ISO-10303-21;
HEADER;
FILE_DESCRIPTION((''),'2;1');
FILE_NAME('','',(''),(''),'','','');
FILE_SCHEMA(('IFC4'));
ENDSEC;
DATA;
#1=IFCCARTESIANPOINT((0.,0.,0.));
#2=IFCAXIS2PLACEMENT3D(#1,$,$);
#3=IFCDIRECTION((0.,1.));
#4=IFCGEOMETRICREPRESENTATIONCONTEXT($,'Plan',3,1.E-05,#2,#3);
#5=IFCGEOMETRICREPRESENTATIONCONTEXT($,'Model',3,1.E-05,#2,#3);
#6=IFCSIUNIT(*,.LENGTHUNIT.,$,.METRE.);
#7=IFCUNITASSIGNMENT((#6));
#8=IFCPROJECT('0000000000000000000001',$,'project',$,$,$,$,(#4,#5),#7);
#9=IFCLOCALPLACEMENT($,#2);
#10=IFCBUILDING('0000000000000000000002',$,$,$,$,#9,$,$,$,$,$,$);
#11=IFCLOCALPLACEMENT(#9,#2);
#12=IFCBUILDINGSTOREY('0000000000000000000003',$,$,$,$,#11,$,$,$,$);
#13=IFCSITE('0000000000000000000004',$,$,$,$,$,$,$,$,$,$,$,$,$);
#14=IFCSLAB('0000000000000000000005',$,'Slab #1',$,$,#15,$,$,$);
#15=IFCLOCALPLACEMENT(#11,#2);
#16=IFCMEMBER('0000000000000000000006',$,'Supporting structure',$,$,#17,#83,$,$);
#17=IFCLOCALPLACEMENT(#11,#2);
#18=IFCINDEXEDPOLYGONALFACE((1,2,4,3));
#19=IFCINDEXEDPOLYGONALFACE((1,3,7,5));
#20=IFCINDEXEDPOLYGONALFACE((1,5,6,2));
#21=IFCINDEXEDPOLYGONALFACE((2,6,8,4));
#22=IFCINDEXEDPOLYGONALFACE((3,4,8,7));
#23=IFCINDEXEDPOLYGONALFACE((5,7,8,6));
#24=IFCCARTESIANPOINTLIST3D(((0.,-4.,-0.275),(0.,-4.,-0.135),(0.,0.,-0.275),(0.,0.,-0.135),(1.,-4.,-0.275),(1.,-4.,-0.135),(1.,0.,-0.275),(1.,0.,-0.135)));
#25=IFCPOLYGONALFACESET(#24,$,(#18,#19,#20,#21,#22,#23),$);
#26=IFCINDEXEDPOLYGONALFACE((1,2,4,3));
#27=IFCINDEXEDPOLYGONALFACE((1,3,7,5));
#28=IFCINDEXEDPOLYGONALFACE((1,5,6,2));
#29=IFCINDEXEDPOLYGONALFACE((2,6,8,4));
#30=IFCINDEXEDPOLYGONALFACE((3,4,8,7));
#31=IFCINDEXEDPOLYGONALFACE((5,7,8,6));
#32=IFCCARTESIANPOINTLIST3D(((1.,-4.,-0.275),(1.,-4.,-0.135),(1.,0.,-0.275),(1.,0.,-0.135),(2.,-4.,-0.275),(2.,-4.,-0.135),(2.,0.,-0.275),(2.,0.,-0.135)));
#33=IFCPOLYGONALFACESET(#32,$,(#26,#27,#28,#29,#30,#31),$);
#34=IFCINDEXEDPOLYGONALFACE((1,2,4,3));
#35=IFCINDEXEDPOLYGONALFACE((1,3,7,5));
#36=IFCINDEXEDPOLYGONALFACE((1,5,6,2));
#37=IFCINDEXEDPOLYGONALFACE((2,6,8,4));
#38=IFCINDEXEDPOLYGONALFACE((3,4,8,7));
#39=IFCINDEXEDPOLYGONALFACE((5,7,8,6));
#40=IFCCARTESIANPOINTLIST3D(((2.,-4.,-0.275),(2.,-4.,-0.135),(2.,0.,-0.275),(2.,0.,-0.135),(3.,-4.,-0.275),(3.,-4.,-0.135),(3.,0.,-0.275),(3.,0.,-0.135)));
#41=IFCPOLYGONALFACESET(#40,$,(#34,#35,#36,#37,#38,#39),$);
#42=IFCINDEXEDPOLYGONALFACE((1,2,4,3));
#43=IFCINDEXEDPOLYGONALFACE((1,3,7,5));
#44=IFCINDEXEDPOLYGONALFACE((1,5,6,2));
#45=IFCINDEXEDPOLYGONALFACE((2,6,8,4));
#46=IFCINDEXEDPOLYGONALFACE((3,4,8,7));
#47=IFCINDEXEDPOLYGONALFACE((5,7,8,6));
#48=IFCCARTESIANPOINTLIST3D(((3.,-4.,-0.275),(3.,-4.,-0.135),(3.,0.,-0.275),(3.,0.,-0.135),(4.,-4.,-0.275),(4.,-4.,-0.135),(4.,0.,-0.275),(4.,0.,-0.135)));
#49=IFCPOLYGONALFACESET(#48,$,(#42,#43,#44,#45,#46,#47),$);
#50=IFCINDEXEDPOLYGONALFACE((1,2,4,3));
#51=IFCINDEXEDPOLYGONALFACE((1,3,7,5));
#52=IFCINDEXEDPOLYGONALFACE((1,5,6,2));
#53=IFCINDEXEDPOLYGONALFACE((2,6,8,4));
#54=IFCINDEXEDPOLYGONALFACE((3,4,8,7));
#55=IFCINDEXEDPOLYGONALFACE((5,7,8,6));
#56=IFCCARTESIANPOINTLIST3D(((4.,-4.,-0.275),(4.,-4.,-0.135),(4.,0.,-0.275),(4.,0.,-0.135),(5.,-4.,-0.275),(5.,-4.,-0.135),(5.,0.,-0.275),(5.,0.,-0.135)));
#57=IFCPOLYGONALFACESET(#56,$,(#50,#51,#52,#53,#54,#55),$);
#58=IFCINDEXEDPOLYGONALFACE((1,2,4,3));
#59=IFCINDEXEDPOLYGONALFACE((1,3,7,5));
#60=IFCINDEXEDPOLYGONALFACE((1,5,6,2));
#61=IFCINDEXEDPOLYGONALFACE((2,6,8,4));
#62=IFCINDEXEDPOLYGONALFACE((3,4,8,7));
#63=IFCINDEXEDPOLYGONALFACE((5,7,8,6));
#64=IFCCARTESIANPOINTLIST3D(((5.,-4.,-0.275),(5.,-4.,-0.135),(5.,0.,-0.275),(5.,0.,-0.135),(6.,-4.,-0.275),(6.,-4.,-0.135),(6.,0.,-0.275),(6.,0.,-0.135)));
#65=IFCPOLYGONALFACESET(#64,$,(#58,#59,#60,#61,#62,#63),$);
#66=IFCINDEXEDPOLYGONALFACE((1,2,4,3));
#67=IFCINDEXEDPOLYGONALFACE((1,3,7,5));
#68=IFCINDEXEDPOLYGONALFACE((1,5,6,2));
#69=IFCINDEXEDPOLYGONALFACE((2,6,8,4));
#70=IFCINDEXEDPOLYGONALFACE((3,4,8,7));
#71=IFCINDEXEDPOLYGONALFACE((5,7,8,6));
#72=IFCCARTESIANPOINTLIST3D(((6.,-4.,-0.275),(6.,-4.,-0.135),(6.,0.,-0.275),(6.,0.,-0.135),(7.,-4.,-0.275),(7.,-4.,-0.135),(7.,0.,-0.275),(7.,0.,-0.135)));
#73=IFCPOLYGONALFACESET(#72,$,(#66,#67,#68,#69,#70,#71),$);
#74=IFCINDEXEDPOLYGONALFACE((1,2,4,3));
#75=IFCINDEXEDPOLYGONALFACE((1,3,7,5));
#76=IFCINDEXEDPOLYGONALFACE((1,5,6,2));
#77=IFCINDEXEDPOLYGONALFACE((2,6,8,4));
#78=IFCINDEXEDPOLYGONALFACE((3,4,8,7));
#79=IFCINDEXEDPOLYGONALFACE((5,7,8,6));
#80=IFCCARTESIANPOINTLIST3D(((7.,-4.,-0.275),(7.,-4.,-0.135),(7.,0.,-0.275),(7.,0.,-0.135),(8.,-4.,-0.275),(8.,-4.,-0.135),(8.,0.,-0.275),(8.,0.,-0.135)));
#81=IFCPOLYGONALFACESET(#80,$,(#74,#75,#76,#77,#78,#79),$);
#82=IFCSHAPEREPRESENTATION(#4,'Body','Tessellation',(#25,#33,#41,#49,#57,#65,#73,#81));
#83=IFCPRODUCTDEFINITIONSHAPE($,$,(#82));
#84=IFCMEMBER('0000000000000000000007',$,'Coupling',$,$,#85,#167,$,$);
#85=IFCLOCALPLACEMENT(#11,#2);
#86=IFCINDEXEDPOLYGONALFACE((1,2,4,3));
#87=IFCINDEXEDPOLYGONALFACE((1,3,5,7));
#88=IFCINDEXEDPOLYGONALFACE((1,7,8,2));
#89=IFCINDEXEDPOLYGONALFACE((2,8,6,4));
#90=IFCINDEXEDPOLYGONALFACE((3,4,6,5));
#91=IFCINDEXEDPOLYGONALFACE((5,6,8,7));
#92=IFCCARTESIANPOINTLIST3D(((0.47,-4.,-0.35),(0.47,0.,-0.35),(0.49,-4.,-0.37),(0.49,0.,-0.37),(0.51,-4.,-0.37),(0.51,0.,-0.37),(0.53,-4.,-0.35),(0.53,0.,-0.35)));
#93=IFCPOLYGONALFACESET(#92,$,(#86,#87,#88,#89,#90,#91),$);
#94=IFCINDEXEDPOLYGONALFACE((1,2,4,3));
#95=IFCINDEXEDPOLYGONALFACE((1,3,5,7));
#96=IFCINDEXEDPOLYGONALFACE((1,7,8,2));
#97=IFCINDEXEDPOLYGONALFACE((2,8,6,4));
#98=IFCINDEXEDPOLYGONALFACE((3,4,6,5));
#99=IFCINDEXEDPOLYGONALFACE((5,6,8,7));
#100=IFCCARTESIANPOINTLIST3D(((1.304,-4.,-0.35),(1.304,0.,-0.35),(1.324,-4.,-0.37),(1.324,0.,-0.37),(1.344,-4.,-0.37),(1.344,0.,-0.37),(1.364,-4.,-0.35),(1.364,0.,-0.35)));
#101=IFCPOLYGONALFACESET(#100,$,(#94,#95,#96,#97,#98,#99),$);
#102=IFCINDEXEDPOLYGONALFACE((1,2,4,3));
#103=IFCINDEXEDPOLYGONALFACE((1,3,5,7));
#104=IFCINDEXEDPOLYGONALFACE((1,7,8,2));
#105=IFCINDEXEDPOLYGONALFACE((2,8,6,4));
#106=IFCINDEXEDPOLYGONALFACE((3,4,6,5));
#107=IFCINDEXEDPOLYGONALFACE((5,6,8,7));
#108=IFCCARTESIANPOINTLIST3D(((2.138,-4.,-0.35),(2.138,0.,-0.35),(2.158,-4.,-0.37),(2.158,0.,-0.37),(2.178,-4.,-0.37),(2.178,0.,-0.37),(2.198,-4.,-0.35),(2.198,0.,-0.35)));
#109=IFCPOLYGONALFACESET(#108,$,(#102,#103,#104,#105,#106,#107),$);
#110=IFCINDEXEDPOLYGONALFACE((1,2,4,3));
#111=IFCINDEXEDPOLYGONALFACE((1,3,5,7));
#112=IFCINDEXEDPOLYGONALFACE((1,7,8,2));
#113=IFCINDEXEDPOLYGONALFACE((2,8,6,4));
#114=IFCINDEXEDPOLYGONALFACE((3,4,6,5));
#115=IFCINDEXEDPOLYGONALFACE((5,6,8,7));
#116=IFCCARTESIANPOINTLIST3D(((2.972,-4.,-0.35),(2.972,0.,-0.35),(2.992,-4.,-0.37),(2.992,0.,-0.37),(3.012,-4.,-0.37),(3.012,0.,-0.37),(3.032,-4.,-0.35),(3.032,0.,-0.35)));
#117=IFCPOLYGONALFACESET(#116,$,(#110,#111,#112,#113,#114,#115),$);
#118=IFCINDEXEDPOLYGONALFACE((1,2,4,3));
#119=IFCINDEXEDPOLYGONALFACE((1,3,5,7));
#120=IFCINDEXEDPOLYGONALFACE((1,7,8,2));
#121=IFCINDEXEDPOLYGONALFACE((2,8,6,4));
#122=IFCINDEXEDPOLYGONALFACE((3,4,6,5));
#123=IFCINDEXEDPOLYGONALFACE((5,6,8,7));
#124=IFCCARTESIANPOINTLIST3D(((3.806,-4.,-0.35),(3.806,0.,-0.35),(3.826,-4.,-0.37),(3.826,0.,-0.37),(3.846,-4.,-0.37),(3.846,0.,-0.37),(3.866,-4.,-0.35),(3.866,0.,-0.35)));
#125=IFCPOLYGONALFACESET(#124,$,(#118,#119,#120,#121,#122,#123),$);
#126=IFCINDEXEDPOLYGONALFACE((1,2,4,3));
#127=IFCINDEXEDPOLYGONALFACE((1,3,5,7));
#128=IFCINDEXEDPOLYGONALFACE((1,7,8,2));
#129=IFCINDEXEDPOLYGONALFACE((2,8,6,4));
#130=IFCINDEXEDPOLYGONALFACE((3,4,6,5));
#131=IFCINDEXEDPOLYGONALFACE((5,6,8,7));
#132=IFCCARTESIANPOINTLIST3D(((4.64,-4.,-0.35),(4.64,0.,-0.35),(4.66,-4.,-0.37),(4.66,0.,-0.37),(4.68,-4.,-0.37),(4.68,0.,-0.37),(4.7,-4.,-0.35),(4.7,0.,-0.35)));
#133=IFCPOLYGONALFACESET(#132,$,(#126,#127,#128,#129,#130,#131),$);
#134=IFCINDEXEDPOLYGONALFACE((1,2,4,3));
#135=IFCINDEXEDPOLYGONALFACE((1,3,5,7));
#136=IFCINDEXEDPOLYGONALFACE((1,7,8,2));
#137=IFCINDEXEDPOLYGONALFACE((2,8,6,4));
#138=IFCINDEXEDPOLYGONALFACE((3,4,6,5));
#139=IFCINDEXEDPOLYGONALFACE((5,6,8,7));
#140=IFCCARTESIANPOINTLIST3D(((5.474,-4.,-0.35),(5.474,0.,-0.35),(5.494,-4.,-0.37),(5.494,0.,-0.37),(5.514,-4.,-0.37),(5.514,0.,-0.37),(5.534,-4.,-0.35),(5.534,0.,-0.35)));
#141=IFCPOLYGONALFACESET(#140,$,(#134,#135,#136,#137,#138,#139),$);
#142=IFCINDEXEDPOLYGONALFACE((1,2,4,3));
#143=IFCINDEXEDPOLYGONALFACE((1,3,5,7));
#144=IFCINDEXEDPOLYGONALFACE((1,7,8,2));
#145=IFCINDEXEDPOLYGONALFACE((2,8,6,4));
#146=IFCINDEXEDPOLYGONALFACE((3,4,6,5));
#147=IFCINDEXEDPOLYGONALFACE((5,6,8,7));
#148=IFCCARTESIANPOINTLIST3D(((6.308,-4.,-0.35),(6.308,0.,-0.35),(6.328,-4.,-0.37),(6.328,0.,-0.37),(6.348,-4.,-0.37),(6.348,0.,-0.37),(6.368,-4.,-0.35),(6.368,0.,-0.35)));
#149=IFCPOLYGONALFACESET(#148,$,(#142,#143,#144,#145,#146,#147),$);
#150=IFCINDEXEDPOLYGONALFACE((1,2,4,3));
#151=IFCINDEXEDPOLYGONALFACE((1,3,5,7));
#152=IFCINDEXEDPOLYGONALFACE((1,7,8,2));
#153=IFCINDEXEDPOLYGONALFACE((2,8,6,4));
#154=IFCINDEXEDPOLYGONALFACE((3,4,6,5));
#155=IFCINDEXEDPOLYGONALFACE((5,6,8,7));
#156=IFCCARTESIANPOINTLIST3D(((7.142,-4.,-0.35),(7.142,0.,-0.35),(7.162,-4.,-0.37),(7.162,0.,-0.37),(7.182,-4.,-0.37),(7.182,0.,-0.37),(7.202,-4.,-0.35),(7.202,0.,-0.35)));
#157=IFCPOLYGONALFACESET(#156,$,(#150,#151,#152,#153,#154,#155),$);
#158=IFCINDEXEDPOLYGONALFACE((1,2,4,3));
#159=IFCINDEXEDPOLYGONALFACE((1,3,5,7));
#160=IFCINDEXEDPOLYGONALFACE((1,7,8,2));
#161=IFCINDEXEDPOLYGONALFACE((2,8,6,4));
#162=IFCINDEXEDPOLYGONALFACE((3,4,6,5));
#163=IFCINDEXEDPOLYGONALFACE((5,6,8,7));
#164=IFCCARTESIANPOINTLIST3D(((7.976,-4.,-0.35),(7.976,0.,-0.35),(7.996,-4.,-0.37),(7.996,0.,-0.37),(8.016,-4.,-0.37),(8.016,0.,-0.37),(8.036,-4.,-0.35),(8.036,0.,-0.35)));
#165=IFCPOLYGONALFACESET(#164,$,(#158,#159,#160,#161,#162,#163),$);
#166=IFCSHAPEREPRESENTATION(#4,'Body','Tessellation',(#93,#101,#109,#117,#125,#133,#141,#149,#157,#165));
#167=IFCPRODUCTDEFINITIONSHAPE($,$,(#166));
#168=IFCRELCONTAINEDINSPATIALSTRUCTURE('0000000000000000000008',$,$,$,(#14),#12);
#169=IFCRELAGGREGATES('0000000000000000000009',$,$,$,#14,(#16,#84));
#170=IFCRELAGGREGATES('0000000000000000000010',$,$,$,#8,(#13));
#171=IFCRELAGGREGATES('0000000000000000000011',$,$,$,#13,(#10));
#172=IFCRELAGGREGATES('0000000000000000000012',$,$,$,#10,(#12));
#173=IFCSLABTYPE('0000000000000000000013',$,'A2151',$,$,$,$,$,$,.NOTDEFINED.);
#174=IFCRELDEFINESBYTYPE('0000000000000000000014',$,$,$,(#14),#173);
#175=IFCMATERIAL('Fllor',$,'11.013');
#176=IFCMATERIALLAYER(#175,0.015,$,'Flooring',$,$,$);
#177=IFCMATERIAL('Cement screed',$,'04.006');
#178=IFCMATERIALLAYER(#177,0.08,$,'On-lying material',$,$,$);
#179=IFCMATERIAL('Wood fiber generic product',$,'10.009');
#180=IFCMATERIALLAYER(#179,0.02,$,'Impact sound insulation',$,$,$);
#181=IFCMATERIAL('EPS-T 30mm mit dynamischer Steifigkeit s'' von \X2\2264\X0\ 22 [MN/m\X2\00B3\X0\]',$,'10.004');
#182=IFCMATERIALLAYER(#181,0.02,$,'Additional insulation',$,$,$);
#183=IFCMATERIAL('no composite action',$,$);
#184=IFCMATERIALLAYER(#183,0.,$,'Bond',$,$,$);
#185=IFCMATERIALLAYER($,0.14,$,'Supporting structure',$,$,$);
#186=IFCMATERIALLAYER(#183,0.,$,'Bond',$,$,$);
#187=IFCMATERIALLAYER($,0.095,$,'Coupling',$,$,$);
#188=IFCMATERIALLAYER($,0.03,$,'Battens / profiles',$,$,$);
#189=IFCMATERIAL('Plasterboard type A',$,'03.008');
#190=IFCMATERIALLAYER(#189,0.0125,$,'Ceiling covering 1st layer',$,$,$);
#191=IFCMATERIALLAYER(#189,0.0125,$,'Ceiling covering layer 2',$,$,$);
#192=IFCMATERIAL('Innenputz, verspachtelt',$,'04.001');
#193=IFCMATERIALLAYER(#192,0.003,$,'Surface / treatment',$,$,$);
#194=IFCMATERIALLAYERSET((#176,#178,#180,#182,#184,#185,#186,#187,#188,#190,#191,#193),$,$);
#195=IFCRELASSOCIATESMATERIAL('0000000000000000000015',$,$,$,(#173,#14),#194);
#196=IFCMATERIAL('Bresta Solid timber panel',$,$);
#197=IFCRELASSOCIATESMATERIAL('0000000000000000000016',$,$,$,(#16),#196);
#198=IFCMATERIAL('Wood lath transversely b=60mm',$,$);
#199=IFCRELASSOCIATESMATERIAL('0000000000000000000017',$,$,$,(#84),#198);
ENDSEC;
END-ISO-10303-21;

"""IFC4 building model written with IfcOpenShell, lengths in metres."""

from ifc_helpers import new_model, si_unit, direction, frame, frame_2d, origin, place, context, project, spatial, polyline, rectangle, outline, extrude, material, layer, layer_set, type_object, element, aggregate, save


model = new_model("IFC4")

# Units and contexts
plan_context = context("Plan", 3, precision=1e-05, world=origin(), true_north=direction((0.0, 1.0)))
model_context = context("Model", 3, precision=1e-05, world=origin(), true_north=direction((0.0, 1.0)))
ifc_project = project(units=[si_unit("LENGTHUNIT", "METRE")], contexts=[plan_context, model_context])

# Site, building, storey
site = spatial("IfcSite", under=ifc_project)
building_placement = place(None, origin())
building = spatial("IfcBuilding", under=site, at=building_placement)
storey_placement = place(building_placement, origin())
storey = spatial("IfcBuildingStorey", under=building, at=storey_placement)

# Slab, members
ifc_material_1 = material(Name="Fllor", Category="11.013")
ifc_layer_1 = layer(ifc_material_1, 0.015, Name="Flooring")
ifc_material_2 = material(Name="Cement screed", Category="04.006")
ifc_layer_2 = layer(ifc_material_2, 0.08, Name="On-lying material")
ifc_material_3 = material(Name="Wood fiber generic product", Category="10.009")
ifc_layer_3 = layer(ifc_material_3, 0.02, Name="Impact sound insulation")
ifc_material_4 = material(Name="EPS-T 30mm mit dynamischer Steifigkeit s' von ≤ 22 [MN/m³]", Category="10.004")
ifc_layer_4 = layer(ifc_material_4, 0.02, Name="Additional insulation")
ifc_material_5 = material(Name="no composite action")
ifc_layer_5 = layer(ifc_material_5, 0.0, Name="Bond")
ifc_layer_6 = layer(None, 0.14, Name="Supporting structure")
ifc_layer_7 = layer(ifc_material_5, 0.0, Name="Bond")
ifc_layer_8 = layer(None, 0.095, Name="Coupling")
ifc_layer_9 = layer(None, 0.03, Name="Battens / profiles")
ifc_material_6 = material(Name="Plasterboard type A", Category="03.008")
ifc_layer_10 = layer(ifc_material_6, 0.0125, Name="Ceiling covering 1st layer")
ifc_layer_11 = layer(ifc_material_6, 0.0125, Name="Ceiling covering layer 2")
ifc_material_7 = material(Name="Innenputz, verspachtelt", Category="04.001")
ifc_layer_12 = layer(ifc_material_7, 0.003, Name="Surface / treatment")
ifc_layer_set = layer_set([ifc_layer_1, ifc_layer_2, ifc_layer_3, ifc_layer_4, ifc_layer_5, ifc_layer_6, ifc_layer_7, ifc_layer_8, ifc_layer_9, ifc_layer_10, ifc_layer_11, ifc_layer_12])
slab_type = type_object("IfcSlabType", Name="A2151", PredefinedType="NOTDEFINED", material=ifc_layer_set)
slab_placement = place(None, frame((0.0, 0.0, 0.0), z_axis=(0.0, 0.0, -1.0), x_axis=(1.0, 0.0, 0.0)))
slab = element("IfcSlab", 1, at=slab_placement, inside=storey, type_object=slab_type, material=ifc_layer_set, Name="Slab #1")
ifc_material_8 = material(Name="Bresta Solid timber panel")
member_1_placement = place(slab_placement, origin())
member_1 = element("IfcMember", 2, at=member_1_placement, material=ifc_material_8, Name="Supporting structure", context=plan_context, shape_type="SweptSolid", body=[
    extrude(rectangle(XDim=1.0, YDim=0.14, at=frame_2d((0.5, 0.07), x_axis=(1.0, 0.0))), frame((0.0, 4.0, 0.135), z_axis=(0.0, -1.0, 0.0), x_axis=(1.0, 0.0, 0.0)), (0.0, 0.0, 1.0), 4.0),
    extrude(rectangle(XDim=1.0, YDim=0.14, at=frame_2d((0.5, 0.07), x_axis=(1.0, 0.0))), frame((1.0, 4.0, 0.135), z_axis=(0.0, -1.0, 0.0), x_axis=(1.0, 0.0, 0.0)), (0.0, 0.0, 1.0), 4.0),
    extrude(rectangle(XDim=1.0, YDim=0.14, at=frame_2d((0.5, 0.07), x_axis=(1.0, 0.0))), frame((2.0, 4.0, 0.135), z_axis=(0.0, -1.0, 0.0), x_axis=(1.0, 0.0, 0.0)), (0.0, 0.0, 1.0), 4.0),
    extrude(rectangle(XDim=1.0, YDim=0.14, at=frame_2d((0.5, 0.07), x_axis=(1.0, 0.0))), frame((3.0, 4.0, 0.135), z_axis=(0.0, -1.0, 0.0), x_axis=(1.0, 0.0, 0.0)), (0.0, 0.0, 1.0), 4.0),
    extrude(rectangle(XDim=1.0, YDim=0.14, at=frame_2d((0.5, 0.07), x_axis=(1.0, 0.0))), frame((4.0, 4.0, 0.135), z_axis=(0.0, -1.0, 0.0), x_axis=(1.0, 0.0, 0.0)), (0.0, 0.0, 1.0), 4.0),
    extrude(rectangle(XDim=1.0, YDim=0.14, at=frame_2d((0.5, 0.07), x_axis=(1.0, 0.0))), frame((5.0, 4.0, 0.135), z_axis=(0.0, -1.0, 0.0), x_axis=(1.0, 0.0, 0.0)), (0.0, 0.0, 1.0), 4.0),
    extrude(rectangle(XDim=1.0, YDim=0.14, at=frame_2d((0.5, 0.07), x_axis=(1.0, 0.0))), frame((6.0, 4.0, 0.135), z_axis=(0.0, -1.0, 0.0), x_axis=(1.0, 0.0, 0.0)), (0.0, 0.0, 1.0), 4.0),
    extrude(rectangle(XDim=1.0, YDim=0.14, at=frame_2d((0.5, 0.07), x_axis=(1.0, 0.0))), frame((7.0, 4.0, 0.135), z_axis=(0.0, -1.0, 0.0), x_axis=(1.0, 0.0, 0.0)), (0.0, 0.0, 1.0), 4.0),
])
ifc_material_9 = material(Name="Wood lath transversely b=60mm")
member_2_placement = place(slab_placement, origin())
member_2 = element("IfcMember", 3, at=member_2_placement, material=ifc_material_9, Name="Coupling", context=plan_context, shape_type="SweptSolid", body=[
    extrude(outline(polyline([(0.0, 0.0), (0.06, 0.0), (0.04, 0.02), (0.02, 0.02), (0.0, 0.0)])), frame((0.47, 4.0, 0.35), z_axis=(0.0, -1.0, 0.0), x_axis=(1.0, 0.0, 0.0)), (0.0, 0.0, 1.0), 4.0),
    extrude(outline(polyline([(0.0, 0.0), (0.06, 0.0), (0.04, 0.02), (0.02, 0.02), (0.0, 0.0)])), frame((1.304, 4.0, 0.35), z_axis=(0.0, -1.0, 0.0), x_axis=(1.0, 0.0, 0.0)), (0.0, 0.0, 1.0), 4.0),
    extrude(outline(polyline([(0.0, 0.0), (0.06, 0.0), (0.04, 0.02), (0.02, 0.02), (0.0, 0.0)])), frame((2.138, 4.0, 0.35), z_axis=(0.0, -1.0, 0.0), x_axis=(1.0, 0.0, 0.0)), (0.0, 0.0, 1.0), 4.0),
    extrude(outline(polyline([(0.0, 0.0), (0.06, 0.0), (0.04, 0.02), (0.02, 0.02), (0.0, 0.0)])), frame((2.972, 4.0, 0.35), z_axis=(0.0, -1.0, 0.0), x_axis=(1.0, 0.0, 0.0)), (0.0, 0.0, 1.0), 4.0),
    extrude(outline(polyline([(0.0, 0.0), (0.06, 0.0), (0.04, 0.02), (0.02, 0.02), (0.0, 0.0)])), frame((3.806, 4.0, 0.35), z_axis=(0.0, -1.0, 0.0), x_axis=(1.0, 0.0, 0.0)), (0.0, 0.0, 1.0), 4.0),
    extrude(outline(polyline([(0.0, 0.0), (0.06, 0.0), (0.04, 0.02), (0.02, 0.02), (0.0, 0.0)])), frame((4.64, 4.0, 0.35), z_axis=(0.0, -1.0, 0.0), x_axis=(1.0, 0.0, 0.0)), (0.0, 0.0, 1.0), 4.0),
    extrude(outline(polyline([(0.0, 0.0), (0.06, 0.0), (0.04, 0.02), (0.02, 0.02), (0.0, 0.0)])), frame((5.474, 4.0, 0.35), z_axis=(0.0, -1.0, 0.0), x_axis=(1.0, 0.0, 0.0)), (0.0, 0.0, 1.0), 4.0),
    extrude(outline(polyline([(0.0, 0.0), (0.06, 0.0), (0.04, 0.02), (0.02, 0.02), (0.0, 0.0)])), frame((6.308, 4.0, 0.35), z_axis=(0.0, -1.0, 0.0), x_axis=(1.0, 0.0, 0.0)), (0.0, 0.0, 1.0), 4.0),
    extrude(outline(polyline([(0.0, 0.0), (0.06, 0.0), (0.04, 0.02), (0.02, 0.02), (0.0, 0.0)])), frame((7.142, 4.0, 0.35), z_axis=(0.0, -1.0, 0.0), x_axis=(1.0, 0.0, 0.0)), (0.0, 0.0, 1.0), 4.0),
    extrude(outline(polyline([(0.0, 0.0), (0.06, 0.0), (0.04, 0.02), (0.02, 0.02), (0.0, 0.0)])), frame((7.976, 4.0, 0.35), z_axis=(0.0, -1.0, 0.0), x_axis=(1.0, 0.0, 0.0)), (0.0, 0.0, 1.0), 4.0),
])
aggregate(slab, [member_1, member_2])

save(model, "model.ifc")
